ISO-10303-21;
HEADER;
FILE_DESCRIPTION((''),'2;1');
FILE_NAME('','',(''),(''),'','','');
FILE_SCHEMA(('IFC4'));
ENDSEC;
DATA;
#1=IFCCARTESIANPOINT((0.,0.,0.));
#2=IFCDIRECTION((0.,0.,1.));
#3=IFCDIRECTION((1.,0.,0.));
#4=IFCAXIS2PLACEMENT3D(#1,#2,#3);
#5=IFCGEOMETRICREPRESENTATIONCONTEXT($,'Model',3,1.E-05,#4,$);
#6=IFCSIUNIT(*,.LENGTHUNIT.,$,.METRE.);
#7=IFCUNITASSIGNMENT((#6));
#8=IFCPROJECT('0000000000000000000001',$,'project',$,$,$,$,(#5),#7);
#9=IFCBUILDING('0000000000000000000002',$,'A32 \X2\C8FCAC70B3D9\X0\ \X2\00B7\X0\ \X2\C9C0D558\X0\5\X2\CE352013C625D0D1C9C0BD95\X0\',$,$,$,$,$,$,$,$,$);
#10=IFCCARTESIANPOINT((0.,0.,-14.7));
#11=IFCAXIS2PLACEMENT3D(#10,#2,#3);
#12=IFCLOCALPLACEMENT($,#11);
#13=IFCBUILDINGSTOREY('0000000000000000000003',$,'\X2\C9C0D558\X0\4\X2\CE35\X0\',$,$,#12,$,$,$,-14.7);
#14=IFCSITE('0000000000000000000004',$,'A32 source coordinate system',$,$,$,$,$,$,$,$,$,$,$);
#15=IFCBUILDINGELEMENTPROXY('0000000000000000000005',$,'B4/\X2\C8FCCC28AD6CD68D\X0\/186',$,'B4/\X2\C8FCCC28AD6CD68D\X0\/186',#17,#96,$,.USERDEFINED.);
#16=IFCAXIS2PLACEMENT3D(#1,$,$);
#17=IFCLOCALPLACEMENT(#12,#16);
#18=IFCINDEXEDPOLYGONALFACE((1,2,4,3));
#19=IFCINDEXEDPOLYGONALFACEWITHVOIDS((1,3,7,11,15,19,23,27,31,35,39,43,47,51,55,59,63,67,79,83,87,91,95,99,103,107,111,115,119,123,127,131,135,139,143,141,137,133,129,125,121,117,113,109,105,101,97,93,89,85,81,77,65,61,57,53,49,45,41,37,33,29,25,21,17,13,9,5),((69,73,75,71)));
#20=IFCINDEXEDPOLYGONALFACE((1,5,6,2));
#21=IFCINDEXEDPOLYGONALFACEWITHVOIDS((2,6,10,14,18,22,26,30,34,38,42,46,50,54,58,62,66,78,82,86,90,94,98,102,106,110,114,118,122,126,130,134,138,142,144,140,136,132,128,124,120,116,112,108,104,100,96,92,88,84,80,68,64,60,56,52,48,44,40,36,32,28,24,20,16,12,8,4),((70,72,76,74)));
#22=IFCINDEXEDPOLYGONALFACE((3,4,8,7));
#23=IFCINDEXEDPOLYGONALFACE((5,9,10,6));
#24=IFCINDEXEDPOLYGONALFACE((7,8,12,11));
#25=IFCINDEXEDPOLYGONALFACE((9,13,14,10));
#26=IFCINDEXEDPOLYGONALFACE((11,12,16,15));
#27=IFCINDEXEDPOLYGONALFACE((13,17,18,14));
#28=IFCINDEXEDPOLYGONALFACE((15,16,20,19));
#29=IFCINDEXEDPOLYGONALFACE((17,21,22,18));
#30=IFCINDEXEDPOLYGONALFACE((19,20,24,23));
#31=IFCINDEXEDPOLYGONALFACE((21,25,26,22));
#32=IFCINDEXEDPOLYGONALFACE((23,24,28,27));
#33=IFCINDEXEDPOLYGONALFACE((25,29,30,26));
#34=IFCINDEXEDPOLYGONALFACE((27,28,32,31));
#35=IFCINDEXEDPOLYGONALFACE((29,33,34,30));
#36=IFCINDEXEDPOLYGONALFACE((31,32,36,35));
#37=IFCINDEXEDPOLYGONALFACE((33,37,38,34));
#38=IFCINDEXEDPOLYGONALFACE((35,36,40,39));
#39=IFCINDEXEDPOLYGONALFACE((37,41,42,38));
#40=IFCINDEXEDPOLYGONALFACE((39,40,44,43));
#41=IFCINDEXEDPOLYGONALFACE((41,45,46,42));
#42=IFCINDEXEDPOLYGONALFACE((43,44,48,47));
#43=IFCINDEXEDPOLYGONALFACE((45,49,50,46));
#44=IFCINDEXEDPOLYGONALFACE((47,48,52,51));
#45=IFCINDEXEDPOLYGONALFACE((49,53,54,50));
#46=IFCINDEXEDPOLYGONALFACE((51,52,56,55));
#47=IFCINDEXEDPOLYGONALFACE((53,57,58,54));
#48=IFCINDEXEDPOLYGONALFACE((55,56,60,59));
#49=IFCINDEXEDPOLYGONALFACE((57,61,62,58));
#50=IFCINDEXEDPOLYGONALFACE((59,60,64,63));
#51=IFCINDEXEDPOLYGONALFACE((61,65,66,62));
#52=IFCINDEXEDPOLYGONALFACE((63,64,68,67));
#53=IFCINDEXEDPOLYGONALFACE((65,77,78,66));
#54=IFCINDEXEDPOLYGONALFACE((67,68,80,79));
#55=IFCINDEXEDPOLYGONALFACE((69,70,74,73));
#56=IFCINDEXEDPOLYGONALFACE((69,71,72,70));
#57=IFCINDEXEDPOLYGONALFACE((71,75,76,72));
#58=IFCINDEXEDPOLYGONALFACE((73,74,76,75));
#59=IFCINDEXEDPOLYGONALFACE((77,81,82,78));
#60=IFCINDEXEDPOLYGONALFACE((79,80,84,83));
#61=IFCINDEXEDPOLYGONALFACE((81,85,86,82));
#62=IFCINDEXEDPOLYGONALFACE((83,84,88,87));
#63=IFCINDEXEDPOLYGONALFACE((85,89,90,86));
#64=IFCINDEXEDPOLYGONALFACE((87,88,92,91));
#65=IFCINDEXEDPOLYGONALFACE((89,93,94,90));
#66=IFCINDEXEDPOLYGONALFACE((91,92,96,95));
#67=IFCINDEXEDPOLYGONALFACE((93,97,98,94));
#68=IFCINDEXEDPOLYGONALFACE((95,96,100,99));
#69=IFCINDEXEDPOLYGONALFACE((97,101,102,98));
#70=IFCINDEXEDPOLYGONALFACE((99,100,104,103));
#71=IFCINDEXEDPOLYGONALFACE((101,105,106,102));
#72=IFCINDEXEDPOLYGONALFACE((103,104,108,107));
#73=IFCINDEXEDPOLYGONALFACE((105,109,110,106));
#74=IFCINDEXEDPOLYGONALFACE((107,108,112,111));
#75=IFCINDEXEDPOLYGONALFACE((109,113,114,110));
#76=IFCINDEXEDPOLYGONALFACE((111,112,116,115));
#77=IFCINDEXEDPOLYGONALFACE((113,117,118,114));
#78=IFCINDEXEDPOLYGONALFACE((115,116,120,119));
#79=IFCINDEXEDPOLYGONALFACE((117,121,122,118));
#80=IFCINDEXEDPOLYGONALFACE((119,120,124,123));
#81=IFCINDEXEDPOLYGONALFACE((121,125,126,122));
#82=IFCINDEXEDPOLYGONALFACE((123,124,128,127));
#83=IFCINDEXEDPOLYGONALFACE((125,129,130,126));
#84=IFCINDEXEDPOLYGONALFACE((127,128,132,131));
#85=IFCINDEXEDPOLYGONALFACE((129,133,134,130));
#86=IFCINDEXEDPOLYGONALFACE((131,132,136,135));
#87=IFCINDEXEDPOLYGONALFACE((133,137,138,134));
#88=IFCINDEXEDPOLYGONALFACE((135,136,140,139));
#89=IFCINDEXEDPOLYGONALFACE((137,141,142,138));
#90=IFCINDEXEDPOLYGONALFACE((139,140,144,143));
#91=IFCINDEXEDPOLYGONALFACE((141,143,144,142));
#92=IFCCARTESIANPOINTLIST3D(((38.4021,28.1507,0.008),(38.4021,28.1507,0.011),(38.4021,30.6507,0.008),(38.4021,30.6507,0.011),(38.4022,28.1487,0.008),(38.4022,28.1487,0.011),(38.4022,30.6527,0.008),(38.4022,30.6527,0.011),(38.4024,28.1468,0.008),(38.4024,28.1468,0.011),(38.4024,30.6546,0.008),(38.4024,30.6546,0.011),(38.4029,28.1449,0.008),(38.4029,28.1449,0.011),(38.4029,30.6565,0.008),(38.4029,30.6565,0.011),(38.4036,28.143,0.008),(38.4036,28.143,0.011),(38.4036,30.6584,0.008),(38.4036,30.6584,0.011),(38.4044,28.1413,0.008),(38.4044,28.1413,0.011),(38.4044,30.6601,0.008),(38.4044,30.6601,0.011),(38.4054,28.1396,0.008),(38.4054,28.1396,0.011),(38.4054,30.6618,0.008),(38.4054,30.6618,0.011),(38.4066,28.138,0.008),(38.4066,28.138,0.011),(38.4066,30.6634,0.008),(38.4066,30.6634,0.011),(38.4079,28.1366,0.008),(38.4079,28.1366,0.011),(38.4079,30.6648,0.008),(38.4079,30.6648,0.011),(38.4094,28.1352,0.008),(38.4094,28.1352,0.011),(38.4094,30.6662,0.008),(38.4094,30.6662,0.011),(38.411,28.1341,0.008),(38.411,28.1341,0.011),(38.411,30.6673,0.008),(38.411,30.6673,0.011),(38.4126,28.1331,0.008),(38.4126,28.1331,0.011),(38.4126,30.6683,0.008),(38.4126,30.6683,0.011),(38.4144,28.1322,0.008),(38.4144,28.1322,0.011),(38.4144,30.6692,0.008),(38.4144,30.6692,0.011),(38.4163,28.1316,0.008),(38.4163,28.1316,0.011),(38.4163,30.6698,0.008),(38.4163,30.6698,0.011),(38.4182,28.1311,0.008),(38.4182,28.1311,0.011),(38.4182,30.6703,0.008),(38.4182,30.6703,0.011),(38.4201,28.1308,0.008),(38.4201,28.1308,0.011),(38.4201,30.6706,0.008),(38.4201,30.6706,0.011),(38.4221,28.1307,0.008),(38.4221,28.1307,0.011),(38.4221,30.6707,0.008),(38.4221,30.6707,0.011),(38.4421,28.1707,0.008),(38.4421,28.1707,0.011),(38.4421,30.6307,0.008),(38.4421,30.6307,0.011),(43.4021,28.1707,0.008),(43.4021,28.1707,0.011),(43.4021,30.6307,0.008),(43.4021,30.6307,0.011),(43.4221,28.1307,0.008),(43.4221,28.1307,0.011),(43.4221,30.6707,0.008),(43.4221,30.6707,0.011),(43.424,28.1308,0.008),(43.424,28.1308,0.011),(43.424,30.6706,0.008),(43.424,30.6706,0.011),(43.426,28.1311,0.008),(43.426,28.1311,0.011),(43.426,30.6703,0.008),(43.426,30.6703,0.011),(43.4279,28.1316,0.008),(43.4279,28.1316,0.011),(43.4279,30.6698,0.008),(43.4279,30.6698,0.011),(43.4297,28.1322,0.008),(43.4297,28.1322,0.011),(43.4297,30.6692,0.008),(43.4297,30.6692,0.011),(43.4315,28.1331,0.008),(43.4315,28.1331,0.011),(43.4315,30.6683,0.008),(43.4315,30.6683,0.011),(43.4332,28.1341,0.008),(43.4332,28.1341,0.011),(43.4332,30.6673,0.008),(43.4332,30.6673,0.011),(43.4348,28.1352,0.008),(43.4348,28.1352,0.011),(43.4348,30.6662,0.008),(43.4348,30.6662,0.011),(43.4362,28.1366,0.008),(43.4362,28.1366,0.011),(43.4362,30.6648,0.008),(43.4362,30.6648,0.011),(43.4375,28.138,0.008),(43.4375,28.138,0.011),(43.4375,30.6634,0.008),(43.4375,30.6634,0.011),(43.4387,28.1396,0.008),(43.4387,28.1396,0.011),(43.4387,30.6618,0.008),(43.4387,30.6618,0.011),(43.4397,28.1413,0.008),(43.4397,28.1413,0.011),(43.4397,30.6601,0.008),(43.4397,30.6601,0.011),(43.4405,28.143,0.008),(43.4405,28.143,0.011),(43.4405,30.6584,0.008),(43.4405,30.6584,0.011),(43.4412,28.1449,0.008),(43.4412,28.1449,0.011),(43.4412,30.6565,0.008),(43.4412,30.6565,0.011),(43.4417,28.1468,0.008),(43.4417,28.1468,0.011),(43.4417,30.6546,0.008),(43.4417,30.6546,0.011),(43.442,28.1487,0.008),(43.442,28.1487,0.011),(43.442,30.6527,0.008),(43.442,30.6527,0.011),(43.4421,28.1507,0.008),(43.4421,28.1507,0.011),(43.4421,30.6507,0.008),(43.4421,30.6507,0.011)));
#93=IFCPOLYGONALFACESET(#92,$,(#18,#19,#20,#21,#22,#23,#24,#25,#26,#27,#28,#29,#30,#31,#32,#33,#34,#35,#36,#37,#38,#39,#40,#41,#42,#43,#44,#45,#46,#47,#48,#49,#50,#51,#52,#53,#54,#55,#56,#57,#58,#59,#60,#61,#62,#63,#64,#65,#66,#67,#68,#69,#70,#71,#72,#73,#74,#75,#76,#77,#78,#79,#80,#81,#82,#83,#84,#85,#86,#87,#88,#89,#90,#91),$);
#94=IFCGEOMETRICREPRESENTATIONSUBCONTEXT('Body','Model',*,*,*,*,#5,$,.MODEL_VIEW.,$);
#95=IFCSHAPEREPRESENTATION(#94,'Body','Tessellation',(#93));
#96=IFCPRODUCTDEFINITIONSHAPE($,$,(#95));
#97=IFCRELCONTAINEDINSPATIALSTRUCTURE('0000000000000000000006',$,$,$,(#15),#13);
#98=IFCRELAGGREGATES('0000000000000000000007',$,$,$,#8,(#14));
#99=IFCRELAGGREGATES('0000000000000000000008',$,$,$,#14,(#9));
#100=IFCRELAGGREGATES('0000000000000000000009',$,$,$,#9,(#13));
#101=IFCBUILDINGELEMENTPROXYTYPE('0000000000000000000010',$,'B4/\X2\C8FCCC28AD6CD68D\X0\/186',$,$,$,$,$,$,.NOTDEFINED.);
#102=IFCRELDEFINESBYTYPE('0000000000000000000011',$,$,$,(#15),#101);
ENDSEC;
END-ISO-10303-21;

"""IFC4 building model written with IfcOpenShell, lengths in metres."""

from ifc_helpers import new_model, si_unit, frame, origin, origin_with_axes, place, context, subcontext, project, spatial, polyline, outline, extrude, source, transform, mapped, type_object, type_shapes, element, save


model = new_model("IFC4")

# Units and contexts
model_context = context("Model", 3, precision=1e-05, world=origin_with_axes())
body_context = subcontext(model_context, "Body", "Model", "MODEL_VIEW")
ifc_project = project(units=[si_unit("LENGTHUNIT", "METRE")], contexts=[model_context])

# Site, building, storey
site = spatial("IfcSite", under=ifc_project, Name="A32 source coordinate system")
building = spatial("IfcBuilding", under=site, Name="A32 주거동 · 지하5층–옥탑지붕")
storey_placement = place(None, frame((0.0, 0.0, -14.7), z_axis=(0.0, 0.0, 1.0), x_axis=(1.0, 0.0, 0.0)))
storey = spatial("IfcBuildingStorey", under=building, at=storey_placement, Name="지하4층", Elevation=-14.7)

# Building element proxy
building_element_proxy_type_1 = type_object("IfcBuildingElementProxyType", Name="B4/주차구획/186", PredefinedType="NOTDEFINED")
shared_shape_1 = source(origin(), body_context, "Body", "SweptSolid", [
    extrude(outline(polyline([(43.4221, 30.6707), (43.424, 30.6706), (43.426, 30.6703), (43.4279, 30.6698), (43.4297, 30.6692), (43.4315, 30.6683), (43.4332, 30.6673), (43.4348, 30.6662), (43.4362, 30.6648), (43.4375, 30.6634), (43.4387, 30.6618), (43.4397, 30.6601), (43.4405, 30.6584), (43.4412, 30.6565), (43.4417, 30.6546), (43.442, 30.6527), (43.4421, 30.6507), (43.4421, 28.1507), (43.442, 28.1487), (43.4417, 28.1468), (43.4412, 28.1449), (43.4405, 28.143), (43.4397, 28.1413), (43.4387, 28.1396), (43.4375, 28.138), (43.4362, 28.1366), (43.4348, 28.1352), (43.4332, 28.1341), (43.4315, 28.1331), (43.4297, 28.1322), (43.4279, 28.1316), (43.426, 28.1311), (43.424, 28.1308), (43.4221, 28.1307), (38.4221, 28.1307), (38.4201, 28.1308), (38.4182, 28.1311), (38.4163, 28.1316), (38.4144, 28.1322), (38.4126, 28.1331), (38.411, 28.1341), (38.4094, 28.1352), (38.4079, 28.1366), (38.4066, 28.138), (38.4054, 28.1396), (38.4044, 28.1413), (38.4036, 28.143), (38.4029, 28.1449), (38.4024, 28.1468), (38.4022, 28.1487), (38.4021, 28.1507), (38.4021, 30.6507), (38.4022, 30.6527), (38.4024, 30.6546), (38.4029, 30.6565), (38.4036, 30.6584), (38.4044, 30.6601), (38.4054, 30.6618), (38.4066, 30.6634), (38.4079, 30.6648), (38.4094, 30.6662), (38.411, 30.6673), (38.4126, 30.6683), (38.4144, 30.6692), (38.4163, 30.6698), (38.4182, 30.6703), (38.4201, 30.6706), (38.4221, 30.6707), (43.4221, 30.6707)]), holes=[polyline([(43.4021, 30.6307), (38.4421, 30.6307), (38.4421, 28.1707), (43.4021, 28.1707), (43.4021, 30.6307)])]), frame((0.0, 0.0, 0.008)), (0.0, 0.0, 1.0), 0.003),
])
type_shapes(building_element_proxy_type_1, [shared_shape_1])
proxy_1_placement = place(storey_placement, origin_with_axes())
element("IfcBuildingElementProxy", 1, at=proxy_1_placement, inside=storey, type_object=building_element_proxy_type_1, Name="B4/주차구획/186", ObjectType="B4/주차구획/186", PredefinedType="USERDEFINED", context=body_context, shape_type="MappedRepresentation", body=[
    mapped(shared_shape_1, transform((0.0, 0.0, 0.0), scale=1.0)),
])

save(model, "model.ifc")
